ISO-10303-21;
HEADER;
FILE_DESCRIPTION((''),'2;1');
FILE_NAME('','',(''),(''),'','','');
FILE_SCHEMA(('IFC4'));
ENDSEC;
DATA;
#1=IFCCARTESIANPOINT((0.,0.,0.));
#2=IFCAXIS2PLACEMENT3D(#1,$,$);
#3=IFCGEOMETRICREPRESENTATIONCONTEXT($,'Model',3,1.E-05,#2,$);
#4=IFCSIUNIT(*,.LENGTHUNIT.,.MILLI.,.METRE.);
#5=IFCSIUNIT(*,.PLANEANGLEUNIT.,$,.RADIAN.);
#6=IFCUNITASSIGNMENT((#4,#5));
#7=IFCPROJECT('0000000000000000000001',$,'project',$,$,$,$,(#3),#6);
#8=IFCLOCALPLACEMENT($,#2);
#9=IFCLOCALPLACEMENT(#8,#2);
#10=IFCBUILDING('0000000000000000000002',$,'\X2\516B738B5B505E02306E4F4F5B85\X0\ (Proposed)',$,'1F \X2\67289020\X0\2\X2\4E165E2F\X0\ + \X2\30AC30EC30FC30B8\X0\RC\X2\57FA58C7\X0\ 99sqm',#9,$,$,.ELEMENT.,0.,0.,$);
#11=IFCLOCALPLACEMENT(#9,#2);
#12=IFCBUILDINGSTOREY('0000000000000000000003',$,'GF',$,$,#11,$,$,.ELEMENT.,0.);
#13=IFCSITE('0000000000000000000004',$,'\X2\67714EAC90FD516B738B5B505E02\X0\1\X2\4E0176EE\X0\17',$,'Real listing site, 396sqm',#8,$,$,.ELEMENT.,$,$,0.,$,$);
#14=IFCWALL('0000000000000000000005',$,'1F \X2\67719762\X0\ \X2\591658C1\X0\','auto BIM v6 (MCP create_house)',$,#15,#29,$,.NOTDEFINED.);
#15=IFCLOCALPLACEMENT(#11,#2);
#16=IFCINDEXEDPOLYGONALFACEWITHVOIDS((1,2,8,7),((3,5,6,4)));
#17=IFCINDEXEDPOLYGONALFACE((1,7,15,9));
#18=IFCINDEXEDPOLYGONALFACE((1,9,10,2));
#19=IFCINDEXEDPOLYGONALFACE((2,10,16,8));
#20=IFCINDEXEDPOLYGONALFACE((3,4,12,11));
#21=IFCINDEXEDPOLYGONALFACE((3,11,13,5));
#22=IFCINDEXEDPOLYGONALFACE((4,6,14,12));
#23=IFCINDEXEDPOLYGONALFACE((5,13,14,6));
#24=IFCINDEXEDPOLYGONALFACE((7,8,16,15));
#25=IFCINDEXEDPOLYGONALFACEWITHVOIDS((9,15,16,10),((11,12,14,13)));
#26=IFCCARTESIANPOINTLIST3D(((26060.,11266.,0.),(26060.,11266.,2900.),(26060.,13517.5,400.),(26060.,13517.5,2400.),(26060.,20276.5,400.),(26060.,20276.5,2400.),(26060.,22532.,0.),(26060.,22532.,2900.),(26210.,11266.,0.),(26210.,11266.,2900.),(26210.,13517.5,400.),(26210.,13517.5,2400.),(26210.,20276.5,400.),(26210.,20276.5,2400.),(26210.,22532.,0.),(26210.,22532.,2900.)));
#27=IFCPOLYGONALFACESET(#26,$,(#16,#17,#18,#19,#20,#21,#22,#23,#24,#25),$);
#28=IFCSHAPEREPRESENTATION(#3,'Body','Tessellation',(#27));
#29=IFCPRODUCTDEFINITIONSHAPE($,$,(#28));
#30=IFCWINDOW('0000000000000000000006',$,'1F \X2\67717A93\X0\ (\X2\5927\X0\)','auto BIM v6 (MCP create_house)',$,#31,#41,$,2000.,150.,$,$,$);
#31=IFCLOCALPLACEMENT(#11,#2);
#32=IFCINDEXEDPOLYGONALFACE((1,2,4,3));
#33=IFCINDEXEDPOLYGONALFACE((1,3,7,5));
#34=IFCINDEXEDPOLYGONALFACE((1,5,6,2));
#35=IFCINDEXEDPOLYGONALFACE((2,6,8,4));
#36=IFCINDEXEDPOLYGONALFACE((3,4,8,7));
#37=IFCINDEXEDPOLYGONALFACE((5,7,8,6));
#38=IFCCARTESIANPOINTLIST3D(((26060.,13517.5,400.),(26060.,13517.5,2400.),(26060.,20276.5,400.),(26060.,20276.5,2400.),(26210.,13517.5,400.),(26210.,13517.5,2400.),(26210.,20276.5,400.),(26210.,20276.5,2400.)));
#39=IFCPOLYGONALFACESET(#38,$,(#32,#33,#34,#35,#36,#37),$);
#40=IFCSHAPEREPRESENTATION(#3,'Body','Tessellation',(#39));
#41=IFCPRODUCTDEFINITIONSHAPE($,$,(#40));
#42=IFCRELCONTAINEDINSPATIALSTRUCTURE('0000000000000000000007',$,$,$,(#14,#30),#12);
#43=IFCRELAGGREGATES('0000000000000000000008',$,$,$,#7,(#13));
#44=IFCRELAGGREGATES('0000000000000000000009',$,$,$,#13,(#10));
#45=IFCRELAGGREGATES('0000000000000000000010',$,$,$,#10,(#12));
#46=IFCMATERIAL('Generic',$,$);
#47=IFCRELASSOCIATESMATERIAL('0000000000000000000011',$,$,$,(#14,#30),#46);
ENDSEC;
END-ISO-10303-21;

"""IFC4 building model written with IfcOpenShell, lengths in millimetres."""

from ifc_helpers import new_model, si_unit, frame, frame_2d, origin, place, context, project, spatial, rectangle, extrude, material, element, fill, save


model = new_model("IFC4")

# Units and contexts
model_context = context("Model", 3, precision=1e-05, world=origin())
ifc_project = project(units=[si_unit("LENGTHUNIT", "METRE", prefix="MILLI"), si_unit("PLANEANGLEUNIT", "RADIAN")], contexts=[model_context])

# Site, building, storey
site_placement = place(None, origin())
site = spatial("IfcSite", under=ifc_project, at=site_placement, Name="東京都八王子市1丁目17", ObjectType="Real listing site, 396sqm", CompositionType="ELEMENT", RefElevation=0.0)
building_placement = place(site_placement, origin())
building = spatial("IfcBuilding", under=site, at=building_placement, Name="八王子市の住宅 (Proposed)", ObjectType="1F 木造2世帯 + ガレージRC基壇 99sqm", CompositionType="ELEMENT", ElevationOfRefHeight=0.0, ElevationOfTerrain=0.0)
storey_placement = place(building_placement, origin())
storey = spatial("IfcBuildingStorey", under=building, at=storey_placement, Name="GF", CompositionType="ELEMENT", Elevation=0.0)

# Shared definitions
ifc_material = material(Name="Generic")

# Wall, opening, window
wall_1_placement = place(storey_placement, frame((13030.0, 5633.0, 0.0)))
wall_1 = element("IfcWall", 1, at=wall_1_placement, inside=storey, material=ifc_material, Name="1F 東面 外壁", Description="auto BIM v6 (MCP create_house)", PredefinedType="NOTDEFINED", context=model_context, shape_type="SweptSolid", body=[
    extrude(rectangle(XDim=150.0, YDim=11266.0, at=frame_2d((75.0, 5633.0))), frame((13030.0, 5633.0, 0.0)), (0.0, 0.0, 1.0), 2900.0),
])
opening_1_placement = place(storey_placement, frame((13030.0, 6759.0, 200.0)))
opening_1 = element("IfcOpeningElement", 2, at=opening_1_placement, cuts=wall_1, PredefinedType="NOTDEFINED", context=model_context, shape_type="SweptSolid", body=[
    extrude(rectangle(XDim=150.0, YDim=6759.0, at=frame_2d((75.0, 3379.0))), frame((13030.0, 6759.0, 200.0)), (0.0, 0.0, 1.0), 2000.0),
])
window_1_placement = place(storey_placement, frame((13030.0, 6759.0, 200.0)))
window_1 = element("IfcWindow", 3, at=window_1_placement, inside=storey, material=ifc_material, Name="1F 東窓 (大)", Description="auto BIM v6 (MCP create_house)", OverallHeight=2000.0, OverallWidth=150.0, context=model_context, shape_type="SweptSolid", body=[
    extrude(rectangle(XDim=150.0, YDim=6759.0, at=frame_2d((75.0, 3379.0))), frame((13030.0, 6759.0, 200.0)), (0.0, 0.0, 1.0), 2000.0),
])
fill(opening_1, window_1)

save(model, "model.ifc")
